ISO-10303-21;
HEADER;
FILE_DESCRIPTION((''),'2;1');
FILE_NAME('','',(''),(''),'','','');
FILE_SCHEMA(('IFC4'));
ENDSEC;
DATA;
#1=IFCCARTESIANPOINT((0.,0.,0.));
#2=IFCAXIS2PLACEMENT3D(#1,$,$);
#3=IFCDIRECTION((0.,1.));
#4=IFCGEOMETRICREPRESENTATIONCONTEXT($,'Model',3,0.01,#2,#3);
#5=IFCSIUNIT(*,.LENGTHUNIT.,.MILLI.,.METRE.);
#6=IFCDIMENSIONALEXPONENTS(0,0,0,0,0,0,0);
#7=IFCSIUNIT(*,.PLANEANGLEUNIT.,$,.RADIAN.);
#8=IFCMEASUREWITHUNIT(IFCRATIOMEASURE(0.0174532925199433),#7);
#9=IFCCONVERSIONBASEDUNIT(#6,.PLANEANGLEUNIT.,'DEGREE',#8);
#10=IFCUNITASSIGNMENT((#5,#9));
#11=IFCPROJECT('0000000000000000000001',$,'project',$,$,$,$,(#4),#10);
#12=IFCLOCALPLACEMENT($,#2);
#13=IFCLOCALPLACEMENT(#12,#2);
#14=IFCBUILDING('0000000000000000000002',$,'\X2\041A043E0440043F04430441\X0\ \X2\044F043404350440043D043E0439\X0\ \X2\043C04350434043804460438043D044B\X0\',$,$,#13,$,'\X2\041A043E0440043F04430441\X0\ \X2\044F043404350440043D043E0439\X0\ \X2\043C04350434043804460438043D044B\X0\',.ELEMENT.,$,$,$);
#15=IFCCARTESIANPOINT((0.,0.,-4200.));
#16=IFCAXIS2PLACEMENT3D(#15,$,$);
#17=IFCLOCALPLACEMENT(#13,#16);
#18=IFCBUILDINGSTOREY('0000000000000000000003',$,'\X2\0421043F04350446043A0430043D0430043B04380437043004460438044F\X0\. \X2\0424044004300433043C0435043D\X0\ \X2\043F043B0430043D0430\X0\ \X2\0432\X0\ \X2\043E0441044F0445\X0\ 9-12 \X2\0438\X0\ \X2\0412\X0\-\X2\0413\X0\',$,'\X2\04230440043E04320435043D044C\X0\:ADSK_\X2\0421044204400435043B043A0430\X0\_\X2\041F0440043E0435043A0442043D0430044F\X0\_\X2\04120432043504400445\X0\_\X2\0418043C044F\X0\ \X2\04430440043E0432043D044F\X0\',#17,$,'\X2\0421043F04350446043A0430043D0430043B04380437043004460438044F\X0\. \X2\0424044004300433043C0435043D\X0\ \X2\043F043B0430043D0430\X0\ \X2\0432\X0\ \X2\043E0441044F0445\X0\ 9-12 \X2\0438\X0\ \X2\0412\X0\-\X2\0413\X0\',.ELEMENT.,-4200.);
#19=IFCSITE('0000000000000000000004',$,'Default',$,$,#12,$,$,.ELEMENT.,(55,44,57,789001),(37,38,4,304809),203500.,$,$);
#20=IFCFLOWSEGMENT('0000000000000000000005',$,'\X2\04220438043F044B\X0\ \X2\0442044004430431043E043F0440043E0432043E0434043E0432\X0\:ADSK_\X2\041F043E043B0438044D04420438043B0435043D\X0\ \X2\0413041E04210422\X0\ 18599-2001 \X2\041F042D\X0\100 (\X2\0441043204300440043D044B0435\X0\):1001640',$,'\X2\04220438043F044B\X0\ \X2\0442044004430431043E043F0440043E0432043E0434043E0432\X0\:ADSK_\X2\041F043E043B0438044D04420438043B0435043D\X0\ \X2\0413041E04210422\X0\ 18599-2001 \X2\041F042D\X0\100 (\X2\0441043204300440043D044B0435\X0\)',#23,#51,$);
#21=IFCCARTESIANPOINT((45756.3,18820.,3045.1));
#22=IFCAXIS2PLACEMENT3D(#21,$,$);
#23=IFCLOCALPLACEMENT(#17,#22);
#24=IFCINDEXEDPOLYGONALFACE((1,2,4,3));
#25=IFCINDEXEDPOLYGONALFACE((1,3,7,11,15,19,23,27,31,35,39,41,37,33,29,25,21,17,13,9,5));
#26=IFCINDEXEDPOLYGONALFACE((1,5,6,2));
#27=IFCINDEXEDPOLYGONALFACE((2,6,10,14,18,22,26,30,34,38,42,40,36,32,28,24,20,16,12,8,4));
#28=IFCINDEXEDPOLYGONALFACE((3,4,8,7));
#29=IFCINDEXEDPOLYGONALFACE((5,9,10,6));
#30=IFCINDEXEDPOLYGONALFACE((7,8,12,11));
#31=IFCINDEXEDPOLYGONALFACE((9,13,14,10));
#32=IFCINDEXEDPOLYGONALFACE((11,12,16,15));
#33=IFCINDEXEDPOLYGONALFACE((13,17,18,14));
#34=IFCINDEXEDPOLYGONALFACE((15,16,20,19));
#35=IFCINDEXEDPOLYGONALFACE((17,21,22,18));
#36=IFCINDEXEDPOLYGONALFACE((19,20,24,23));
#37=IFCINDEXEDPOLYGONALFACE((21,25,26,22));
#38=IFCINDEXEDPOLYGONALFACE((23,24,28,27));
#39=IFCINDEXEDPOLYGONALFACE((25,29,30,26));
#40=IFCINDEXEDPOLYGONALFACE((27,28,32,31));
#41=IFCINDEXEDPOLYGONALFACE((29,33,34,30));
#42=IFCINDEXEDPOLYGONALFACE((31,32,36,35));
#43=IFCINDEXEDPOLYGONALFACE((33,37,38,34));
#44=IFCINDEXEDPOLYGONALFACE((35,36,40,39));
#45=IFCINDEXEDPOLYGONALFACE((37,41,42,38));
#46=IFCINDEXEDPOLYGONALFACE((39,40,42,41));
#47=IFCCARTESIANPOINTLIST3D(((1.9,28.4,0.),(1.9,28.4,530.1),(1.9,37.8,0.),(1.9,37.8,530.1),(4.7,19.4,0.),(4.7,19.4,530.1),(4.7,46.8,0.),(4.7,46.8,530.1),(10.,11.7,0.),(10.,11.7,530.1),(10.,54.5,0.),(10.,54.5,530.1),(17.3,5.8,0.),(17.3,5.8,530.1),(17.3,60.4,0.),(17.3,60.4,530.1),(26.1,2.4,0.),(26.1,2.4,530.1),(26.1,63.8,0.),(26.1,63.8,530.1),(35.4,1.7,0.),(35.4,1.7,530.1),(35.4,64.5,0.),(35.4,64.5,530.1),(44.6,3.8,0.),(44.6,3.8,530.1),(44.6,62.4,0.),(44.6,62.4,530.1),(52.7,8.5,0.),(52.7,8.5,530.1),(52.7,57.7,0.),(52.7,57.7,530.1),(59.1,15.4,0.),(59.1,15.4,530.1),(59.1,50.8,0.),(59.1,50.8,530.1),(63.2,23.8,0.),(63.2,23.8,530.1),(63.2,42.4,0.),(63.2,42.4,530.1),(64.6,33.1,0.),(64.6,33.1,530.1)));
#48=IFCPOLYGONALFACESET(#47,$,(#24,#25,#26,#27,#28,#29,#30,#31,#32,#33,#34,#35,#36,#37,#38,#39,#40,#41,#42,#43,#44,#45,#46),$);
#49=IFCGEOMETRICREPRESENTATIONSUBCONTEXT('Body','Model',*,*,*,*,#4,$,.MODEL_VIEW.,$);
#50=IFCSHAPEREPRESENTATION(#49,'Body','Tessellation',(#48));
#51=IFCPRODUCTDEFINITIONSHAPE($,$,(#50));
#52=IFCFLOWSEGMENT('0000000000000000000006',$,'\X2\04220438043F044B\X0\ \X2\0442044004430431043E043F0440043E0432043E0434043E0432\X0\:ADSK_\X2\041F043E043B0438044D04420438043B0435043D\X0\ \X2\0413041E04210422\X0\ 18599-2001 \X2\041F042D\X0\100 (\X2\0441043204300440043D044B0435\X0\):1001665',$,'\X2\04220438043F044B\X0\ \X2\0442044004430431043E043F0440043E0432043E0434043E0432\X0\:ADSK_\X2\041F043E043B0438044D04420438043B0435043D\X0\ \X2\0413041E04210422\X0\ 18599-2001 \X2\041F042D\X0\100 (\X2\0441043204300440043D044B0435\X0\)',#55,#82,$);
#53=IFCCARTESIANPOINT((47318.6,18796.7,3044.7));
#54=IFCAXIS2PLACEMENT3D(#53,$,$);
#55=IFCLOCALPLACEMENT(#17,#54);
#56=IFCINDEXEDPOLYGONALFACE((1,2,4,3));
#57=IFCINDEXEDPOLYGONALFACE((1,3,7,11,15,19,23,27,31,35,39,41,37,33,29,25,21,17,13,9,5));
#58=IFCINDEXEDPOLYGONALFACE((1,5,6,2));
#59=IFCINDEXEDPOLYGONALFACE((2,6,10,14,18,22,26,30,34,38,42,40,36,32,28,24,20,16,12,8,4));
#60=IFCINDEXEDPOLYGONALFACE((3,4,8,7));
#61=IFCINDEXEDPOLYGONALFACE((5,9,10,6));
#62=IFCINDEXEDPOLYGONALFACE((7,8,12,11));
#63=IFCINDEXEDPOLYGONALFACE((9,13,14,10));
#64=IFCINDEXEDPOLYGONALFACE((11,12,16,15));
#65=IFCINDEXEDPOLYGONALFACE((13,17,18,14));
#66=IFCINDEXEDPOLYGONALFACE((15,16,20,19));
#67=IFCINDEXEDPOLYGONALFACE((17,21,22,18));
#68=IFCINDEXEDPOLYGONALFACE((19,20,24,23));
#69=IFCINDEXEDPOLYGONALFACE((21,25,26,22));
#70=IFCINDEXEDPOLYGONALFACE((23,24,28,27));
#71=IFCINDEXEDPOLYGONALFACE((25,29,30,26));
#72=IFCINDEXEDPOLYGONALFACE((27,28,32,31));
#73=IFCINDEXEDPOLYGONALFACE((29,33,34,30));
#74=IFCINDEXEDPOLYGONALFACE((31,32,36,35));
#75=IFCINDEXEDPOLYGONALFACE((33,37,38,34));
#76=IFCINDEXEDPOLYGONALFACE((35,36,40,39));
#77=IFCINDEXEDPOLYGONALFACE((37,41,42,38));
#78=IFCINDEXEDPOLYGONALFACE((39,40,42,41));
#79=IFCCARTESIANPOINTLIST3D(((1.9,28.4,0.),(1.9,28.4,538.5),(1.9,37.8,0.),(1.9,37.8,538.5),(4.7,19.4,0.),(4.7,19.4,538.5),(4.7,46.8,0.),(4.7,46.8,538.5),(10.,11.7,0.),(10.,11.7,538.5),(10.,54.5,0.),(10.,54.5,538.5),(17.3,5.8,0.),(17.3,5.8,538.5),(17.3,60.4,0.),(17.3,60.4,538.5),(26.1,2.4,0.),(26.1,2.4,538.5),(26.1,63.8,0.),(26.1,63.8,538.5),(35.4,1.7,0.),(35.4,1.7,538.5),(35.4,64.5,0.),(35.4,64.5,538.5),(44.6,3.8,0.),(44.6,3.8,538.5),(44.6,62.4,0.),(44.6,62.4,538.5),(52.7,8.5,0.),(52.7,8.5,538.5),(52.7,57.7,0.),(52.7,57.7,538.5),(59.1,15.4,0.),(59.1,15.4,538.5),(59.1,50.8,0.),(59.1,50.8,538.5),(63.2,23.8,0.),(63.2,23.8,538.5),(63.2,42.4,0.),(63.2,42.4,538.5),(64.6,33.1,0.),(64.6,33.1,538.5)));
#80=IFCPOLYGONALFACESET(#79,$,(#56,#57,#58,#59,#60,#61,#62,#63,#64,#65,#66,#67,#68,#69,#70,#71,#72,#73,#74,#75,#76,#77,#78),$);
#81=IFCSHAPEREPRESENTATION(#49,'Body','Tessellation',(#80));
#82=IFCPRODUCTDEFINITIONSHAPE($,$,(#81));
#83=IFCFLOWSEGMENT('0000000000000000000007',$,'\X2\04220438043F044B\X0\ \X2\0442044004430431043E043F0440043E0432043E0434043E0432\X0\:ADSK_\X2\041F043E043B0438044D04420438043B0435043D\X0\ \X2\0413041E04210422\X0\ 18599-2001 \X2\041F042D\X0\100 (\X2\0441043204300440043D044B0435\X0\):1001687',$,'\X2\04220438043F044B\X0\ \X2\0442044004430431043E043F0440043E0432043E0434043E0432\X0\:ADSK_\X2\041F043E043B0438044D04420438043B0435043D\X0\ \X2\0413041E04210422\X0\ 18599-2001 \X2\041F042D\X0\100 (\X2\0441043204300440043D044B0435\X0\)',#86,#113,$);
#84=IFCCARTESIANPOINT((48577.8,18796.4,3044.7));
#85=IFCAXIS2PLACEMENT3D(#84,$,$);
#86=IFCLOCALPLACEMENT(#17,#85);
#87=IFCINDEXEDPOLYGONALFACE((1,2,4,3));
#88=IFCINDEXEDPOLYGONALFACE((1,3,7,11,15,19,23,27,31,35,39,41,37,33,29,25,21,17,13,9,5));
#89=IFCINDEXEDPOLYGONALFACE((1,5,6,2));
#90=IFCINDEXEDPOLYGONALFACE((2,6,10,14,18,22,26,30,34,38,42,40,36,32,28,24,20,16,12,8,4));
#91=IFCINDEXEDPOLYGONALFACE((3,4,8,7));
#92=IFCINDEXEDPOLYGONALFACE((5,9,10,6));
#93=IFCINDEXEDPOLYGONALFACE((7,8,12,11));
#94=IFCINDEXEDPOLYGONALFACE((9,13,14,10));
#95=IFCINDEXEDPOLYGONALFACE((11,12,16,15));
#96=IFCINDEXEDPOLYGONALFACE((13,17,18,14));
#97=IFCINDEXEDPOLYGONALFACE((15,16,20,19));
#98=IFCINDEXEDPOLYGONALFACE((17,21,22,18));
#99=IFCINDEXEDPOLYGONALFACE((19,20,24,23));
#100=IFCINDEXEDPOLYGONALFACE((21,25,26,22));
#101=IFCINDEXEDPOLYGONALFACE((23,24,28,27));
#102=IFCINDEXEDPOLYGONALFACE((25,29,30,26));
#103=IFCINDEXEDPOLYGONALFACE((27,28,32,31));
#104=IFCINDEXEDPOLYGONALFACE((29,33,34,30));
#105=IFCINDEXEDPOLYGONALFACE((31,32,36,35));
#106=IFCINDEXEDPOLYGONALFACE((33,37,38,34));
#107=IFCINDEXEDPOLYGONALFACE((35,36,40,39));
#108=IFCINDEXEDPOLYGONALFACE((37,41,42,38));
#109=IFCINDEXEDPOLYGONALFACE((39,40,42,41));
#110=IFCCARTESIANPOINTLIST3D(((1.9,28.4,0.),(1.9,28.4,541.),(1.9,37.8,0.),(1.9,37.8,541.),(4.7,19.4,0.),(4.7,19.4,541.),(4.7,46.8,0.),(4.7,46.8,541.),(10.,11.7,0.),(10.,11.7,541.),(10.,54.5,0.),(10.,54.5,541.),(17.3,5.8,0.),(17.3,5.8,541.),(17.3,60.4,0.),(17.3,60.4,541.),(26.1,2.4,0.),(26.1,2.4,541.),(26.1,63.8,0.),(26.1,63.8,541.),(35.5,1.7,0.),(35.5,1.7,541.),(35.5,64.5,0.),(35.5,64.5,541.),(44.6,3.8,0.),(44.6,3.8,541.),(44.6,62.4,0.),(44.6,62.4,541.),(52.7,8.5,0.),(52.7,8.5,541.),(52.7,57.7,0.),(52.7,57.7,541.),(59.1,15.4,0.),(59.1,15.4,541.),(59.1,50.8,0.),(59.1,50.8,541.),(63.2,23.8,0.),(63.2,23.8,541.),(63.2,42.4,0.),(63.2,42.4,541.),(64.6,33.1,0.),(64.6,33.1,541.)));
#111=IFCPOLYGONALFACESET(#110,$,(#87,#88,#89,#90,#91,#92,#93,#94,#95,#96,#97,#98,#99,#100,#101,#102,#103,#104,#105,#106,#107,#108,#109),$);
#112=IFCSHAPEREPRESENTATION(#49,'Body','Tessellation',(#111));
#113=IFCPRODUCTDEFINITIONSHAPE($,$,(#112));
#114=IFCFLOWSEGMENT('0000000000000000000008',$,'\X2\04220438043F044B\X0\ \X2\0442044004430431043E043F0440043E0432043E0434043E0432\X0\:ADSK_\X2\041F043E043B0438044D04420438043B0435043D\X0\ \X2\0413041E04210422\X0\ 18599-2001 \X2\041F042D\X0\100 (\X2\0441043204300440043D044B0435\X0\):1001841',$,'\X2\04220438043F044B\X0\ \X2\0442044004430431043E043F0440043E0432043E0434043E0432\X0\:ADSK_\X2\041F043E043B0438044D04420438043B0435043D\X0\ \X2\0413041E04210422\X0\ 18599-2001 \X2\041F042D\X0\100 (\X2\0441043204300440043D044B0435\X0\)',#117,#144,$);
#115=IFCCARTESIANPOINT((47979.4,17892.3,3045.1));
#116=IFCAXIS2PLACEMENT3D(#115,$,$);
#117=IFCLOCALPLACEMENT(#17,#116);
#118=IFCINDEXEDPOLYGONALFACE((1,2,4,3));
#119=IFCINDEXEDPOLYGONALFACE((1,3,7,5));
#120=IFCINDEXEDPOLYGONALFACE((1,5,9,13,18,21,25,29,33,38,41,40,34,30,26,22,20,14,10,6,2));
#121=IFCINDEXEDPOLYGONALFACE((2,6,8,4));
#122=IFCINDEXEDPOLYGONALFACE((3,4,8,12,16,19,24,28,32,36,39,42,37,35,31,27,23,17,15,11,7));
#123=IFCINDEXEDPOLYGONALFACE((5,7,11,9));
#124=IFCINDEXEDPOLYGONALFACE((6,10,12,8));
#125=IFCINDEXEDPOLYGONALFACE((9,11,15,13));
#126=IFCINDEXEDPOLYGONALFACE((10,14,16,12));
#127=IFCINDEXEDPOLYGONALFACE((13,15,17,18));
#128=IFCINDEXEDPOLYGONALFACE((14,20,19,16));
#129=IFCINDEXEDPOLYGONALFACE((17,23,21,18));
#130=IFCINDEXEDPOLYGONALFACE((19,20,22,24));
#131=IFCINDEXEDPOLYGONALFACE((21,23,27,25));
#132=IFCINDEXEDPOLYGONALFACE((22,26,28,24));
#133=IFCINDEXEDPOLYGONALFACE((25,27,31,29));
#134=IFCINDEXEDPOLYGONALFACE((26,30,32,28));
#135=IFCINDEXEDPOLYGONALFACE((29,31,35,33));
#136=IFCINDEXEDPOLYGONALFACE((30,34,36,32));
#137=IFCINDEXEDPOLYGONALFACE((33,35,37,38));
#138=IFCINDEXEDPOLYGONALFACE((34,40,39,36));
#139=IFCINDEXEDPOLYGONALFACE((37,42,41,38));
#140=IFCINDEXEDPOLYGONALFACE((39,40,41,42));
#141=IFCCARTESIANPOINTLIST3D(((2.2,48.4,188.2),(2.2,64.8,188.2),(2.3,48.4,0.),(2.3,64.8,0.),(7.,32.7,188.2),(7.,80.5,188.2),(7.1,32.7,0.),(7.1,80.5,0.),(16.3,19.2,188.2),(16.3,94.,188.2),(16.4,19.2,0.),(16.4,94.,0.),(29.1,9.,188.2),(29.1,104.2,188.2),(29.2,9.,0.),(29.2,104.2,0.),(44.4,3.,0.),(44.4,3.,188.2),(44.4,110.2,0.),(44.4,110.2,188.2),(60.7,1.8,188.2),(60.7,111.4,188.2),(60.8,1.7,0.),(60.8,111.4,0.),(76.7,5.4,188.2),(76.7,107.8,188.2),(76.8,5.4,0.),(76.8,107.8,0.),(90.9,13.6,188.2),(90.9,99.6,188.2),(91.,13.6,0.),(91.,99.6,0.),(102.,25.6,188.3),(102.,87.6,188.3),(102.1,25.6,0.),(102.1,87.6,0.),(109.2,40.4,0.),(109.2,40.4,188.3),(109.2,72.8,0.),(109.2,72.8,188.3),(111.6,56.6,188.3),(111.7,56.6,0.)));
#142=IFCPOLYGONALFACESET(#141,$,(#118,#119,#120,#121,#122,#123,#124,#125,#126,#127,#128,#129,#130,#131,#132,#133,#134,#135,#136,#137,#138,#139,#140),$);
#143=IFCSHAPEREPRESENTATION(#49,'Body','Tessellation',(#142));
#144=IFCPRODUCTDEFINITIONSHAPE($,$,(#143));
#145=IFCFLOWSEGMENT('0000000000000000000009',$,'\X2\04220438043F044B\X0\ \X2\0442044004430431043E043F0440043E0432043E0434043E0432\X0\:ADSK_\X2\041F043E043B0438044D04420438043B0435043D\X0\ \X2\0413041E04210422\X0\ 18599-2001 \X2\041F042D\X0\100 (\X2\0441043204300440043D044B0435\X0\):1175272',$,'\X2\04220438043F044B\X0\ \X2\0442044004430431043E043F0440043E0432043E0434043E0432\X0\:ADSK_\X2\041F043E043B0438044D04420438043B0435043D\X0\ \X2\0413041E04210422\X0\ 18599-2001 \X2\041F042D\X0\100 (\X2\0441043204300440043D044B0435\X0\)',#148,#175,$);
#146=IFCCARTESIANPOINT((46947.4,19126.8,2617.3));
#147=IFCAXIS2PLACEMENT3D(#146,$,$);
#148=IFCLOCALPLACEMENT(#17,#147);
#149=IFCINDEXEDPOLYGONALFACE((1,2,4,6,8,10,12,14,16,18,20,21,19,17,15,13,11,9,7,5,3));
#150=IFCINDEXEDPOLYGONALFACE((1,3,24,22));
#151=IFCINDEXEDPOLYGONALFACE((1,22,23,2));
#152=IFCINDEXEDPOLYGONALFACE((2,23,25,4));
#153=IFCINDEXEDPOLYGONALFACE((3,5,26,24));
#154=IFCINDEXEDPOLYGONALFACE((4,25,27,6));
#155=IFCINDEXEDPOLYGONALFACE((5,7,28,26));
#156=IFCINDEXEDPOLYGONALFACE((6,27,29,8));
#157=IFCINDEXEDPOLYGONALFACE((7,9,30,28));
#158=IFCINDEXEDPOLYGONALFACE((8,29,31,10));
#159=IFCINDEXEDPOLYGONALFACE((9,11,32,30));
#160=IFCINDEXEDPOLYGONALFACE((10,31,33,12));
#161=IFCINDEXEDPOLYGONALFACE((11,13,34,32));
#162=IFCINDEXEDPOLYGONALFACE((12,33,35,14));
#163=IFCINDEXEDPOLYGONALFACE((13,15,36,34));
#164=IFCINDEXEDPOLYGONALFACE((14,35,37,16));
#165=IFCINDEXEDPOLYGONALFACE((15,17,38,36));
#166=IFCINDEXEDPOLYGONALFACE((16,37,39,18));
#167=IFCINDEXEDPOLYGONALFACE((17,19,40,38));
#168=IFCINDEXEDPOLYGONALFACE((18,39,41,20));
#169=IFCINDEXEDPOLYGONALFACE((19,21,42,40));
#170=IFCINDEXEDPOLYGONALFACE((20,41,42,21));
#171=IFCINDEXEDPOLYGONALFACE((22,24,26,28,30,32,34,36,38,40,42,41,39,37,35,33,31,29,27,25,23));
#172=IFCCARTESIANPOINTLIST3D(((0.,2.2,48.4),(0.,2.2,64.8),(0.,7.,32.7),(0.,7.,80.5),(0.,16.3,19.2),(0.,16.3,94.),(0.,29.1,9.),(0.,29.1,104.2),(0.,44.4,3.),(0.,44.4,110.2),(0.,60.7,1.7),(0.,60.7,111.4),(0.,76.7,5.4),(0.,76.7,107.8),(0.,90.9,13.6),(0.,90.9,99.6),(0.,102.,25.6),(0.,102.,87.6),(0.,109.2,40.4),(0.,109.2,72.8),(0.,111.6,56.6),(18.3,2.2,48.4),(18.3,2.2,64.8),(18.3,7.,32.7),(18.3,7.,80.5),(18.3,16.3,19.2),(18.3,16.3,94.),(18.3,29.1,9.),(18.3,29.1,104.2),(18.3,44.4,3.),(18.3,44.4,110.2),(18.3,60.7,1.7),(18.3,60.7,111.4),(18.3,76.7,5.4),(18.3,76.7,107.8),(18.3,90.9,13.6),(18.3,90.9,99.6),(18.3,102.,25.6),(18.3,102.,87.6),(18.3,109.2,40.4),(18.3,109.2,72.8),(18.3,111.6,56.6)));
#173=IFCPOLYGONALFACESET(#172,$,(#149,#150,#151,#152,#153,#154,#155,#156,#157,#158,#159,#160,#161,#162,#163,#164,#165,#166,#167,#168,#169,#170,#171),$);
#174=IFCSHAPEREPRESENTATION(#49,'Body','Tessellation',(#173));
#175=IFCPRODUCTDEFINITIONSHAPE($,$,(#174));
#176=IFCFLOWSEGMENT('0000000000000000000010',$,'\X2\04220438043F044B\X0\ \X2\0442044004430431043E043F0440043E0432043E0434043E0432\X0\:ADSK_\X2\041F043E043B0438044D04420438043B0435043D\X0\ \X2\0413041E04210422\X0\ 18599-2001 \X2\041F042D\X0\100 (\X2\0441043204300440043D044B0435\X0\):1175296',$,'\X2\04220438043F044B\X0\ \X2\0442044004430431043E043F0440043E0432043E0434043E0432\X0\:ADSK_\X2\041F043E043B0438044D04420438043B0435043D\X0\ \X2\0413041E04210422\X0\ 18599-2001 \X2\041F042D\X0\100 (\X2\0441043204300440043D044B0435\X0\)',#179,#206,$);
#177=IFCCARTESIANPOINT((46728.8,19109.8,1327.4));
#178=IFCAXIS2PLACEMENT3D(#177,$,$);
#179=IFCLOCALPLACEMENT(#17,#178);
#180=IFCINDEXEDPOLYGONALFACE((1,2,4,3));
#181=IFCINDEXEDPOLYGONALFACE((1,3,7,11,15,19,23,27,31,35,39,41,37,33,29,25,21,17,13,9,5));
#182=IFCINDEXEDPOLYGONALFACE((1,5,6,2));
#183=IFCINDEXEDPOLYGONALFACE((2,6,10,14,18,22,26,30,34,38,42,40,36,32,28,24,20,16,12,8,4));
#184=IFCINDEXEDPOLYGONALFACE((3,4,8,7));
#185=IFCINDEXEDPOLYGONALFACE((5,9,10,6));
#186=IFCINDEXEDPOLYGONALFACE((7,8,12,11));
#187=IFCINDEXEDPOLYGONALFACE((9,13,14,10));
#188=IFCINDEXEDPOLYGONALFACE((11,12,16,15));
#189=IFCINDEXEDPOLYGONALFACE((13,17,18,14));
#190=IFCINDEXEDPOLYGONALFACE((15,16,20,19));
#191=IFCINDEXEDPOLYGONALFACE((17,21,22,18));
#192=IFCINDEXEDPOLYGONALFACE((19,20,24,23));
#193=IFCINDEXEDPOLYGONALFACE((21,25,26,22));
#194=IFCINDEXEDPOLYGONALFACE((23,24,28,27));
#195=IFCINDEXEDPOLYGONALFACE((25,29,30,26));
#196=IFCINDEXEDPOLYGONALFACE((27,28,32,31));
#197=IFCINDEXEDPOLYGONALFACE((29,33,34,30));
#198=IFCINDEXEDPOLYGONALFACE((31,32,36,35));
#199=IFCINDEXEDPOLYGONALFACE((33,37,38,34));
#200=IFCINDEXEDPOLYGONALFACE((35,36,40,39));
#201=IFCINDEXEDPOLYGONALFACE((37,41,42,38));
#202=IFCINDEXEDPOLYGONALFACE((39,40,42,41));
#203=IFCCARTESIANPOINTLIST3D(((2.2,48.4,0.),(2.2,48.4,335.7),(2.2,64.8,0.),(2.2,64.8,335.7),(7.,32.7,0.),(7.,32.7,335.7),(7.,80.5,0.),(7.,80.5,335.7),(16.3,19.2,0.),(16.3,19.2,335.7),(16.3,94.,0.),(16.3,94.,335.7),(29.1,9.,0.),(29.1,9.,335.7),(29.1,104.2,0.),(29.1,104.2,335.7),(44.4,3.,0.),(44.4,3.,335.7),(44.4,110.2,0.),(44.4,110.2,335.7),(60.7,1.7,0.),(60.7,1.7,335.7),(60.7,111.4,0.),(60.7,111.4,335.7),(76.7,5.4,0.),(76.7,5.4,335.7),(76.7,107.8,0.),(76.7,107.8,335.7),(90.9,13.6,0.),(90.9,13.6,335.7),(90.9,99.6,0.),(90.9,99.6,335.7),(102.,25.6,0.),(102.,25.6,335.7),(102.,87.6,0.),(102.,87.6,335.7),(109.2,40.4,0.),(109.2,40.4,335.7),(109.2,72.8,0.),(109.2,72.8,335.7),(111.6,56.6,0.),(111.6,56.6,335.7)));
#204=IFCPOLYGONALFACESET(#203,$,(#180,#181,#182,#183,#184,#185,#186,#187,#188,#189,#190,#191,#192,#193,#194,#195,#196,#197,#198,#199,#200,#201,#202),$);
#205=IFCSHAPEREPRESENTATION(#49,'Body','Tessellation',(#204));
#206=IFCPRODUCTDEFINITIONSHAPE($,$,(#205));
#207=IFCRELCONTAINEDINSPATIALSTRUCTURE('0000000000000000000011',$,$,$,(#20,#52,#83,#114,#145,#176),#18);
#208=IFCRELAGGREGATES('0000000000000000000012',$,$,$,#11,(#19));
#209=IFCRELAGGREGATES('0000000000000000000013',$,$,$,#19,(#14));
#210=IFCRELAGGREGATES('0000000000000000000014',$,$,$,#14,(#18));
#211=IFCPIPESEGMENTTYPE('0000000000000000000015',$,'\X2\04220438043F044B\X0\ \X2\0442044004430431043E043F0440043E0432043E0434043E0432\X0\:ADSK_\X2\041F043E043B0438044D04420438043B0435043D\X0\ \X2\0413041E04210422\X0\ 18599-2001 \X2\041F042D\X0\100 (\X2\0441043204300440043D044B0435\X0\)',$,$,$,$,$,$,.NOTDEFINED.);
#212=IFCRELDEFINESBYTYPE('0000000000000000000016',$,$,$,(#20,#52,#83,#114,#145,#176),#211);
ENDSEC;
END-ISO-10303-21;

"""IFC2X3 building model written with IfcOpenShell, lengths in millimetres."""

from ifc_helpers import new_model, entity, si_unit, converted_unit, direction, frame, frame_2d, origin, origin_2d_with_axis, place, context, subcontext, project, spatial, circle, extrude, type_object, element, save


model = new_model("IFC2X3")

# Units and contexts
model_context = context("Model", 3, precision=0.01, world=origin(), true_north=direction((0.0, 1.0)))
body_context = subcontext(model_context, "Body", "Model", "MODEL_VIEW")
ifc_project = project(units=[si_unit("LENGTHUNIT", "METRE", prefix="MILLI"), converted_unit("PLANEANGLEUNIT", "DEGREE", entity("IfcRatioMeasure", 0.0174532925199433), si_unit("PLANEANGLEUNIT", "RADIAN"), dimensions=[0, 0, 0, 0, 0, 0, 0])], contexts=[model_context])

# Site, building, storey
site_placement = place(None, frame((0.0, 0.0, 0.0)))
site = spatial("IfcSite", under=ifc_project, at=site_placement, Name="Default", CompositionType="ELEMENT", RefLatitude=(55, 44, 57, 789001), RefLongitude=(37, 38, 4, 304809), RefElevation=203500.0)
building_placement = place(site_placement, origin())
building = spatial("IfcBuilding", under=site, at=building_placement, Name="Корпус ядерной медицины", LongName="Корпус ядерной медицины", CompositionType="ELEMENT")
storey_placement = place(building_placement, frame((0.0, 0.0, -4200.0)))
storey = spatial("IfcBuildingStorey", under=building, at=storey_placement, Name="Спецканализация. Фрагмен плана в осях 9-12 и В-Г", ObjectType="Уровень:ADSK_Стрелка_Проектная_Вверх_Имя уровня", LongName="Спецканализация. Фрагмен плана в осях 9-12 и В-Г", CompositionType="ELEMENT", Elevation=-4200.0)

# Flow segments
pipe_segment_type = type_object("IfcPipeSegmentType", Name="Типы трубопроводов:ADSK_Полиэтилен ГОСТ 18599-2001 ПЭ100 (сварные)", PredefinedType="NOTDEFINED")
flow_segment_1_placement = place(storey_placement, frame((45756.3, 18820.0, 3045.1)))
element("IfcFlowSegment", 1, at=flow_segment_1_placement, inside=storey, type_object=pipe_segment_type, Name="Типы трубопроводов:ADSK_Полиэтилен ГОСТ 18599-2001 ПЭ100 (сварные):1001640", ObjectType="Типы трубопроводов:ADSK_Полиэтилен ГОСТ 18599-2001 ПЭ100 (сварные)", context=body_context, shape_type="SweptSolid", body=[
    extrude(circle(Radius=31.5, at=origin_2d_with_axis()), frame((33.1, 33.1, 0.0)), (0.0, 0.0, 1.0), 530.1),
])
flow_segment_2_placement = place(storey_placement, frame((47318.6, 18796.7, 3044.7)))
element("IfcFlowSegment", 2, at=flow_segment_2_placement, inside=storey, type_object=pipe_segment_type, Name="Типы трубопроводов:ADSK_Полиэтилен ГОСТ 18599-2001 ПЭ100 (сварные):1001665", ObjectType="Типы трубопроводов:ADSK_Полиэтилен ГОСТ 18599-2001 ПЭ100 (сварные)", context=body_context, shape_type="SweptSolid", body=[
    extrude(circle(Radius=31.5, at=origin_2d_with_axis()), frame((33.1, 33.1, 0.0)), (0.0, 0.0, 1.0), 538.5),
])
flow_segment_3_placement = place(storey_placement, frame((48577.8, 18796.4, 3044.7)))
element("IfcFlowSegment", 3, at=flow_segment_3_placement, inside=storey, type_object=pipe_segment_type, Name="Типы трубопроводов:ADSK_Полиэтилен ГОСТ 18599-2001 ПЭ100 (сварные):1001687", ObjectType="Типы трубопроводов:ADSK_Полиэтилен ГОСТ 18599-2001 ПЭ100 (сварные)", context=body_context, shape_type="SweptSolid", body=[
    extrude(circle(Radius=31.5, at=frame_2d((0.0, 0.0), x_axis=(1.0, 0.0))), frame((33.1, 33.1, 0.0)), (0.0, 0.0, 1.0), 541.0),
])
flow_segment_4_placement = place(storey_placement, frame((47979.4, 17892.3, 3045.1)))
element("IfcFlowSegment", 4, at=flow_segment_4_placement, inside=storey, type_object=pipe_segment_type, Name="Типы трубопроводов:ADSK_Полиэтилен ГОСТ 18599-2001 ПЭ100 (сварные):1001841", ObjectType="Типы трубопроводов:ADSK_Полиэтилен ГОСТ 18599-2001 ПЭ100 (сварные)", context=body_context, shape_type="SweptSolid", body=[
    extrude(circle(Radius=55.0, at=origin_2d_with_axis()), frame((56.7, 56.6, 0.0), z_axis=(-0.000404, 0.000006, 1.0), x_axis=(1.0, 0.0, 0.000404)), (0.0, 0.0, 1.0), 188.2),
])
flow_segment_5_placement = place(storey_placement, frame((46947.4, 19126.8, 2617.3)))
element("IfcFlowSegment", 5, at=flow_segment_5_placement, inside=storey, type_object=pipe_segment_type, Name="Типы трубопроводов:ADSK_Полиэтилен ГОСТ 18599-2001 ПЭ100 (сварные):1175272", ObjectType="Типы трубопроводов:ADSK_Полиэтилен ГОСТ 18599-2001 ПЭ100 (сварные)", context=body_context, shape_type="SweptSolid", body=[
    extrude(circle(Radius=55.0, at=origin_2d_with_axis()), frame((0.0, 56.6, 56.6), z_axis=(1.0, 0.0, 0.0), x_axis=(0.0, 1.0, 0.0)), (0.0, 0.0, 1.0), 18.3),
])
flow_segment_6_placement = place(storey_placement, frame((46728.8, 19109.8, 1327.4)))
element("IfcFlowSegment", 6, at=flow_segment_6_placement, inside=storey, type_object=pipe_segment_type, Name="Типы трубопроводов:ADSK_Полиэтилен ГОСТ 18599-2001 ПЭ100 (сварные):1175296", ObjectType="Типы трубопроводов:ADSK_Полиэтилен ГОСТ 18599-2001 ПЭ100 (сварные)", context=body_context, shape_type="SweptSolid", body=[
    extrude(circle(Radius=55.0, at=origin_2d_with_axis()), frame((56.6, 56.6, 0.0)), (0.0, 0.0, 1.0), 335.7),
])

save(model, "model.ifc")
